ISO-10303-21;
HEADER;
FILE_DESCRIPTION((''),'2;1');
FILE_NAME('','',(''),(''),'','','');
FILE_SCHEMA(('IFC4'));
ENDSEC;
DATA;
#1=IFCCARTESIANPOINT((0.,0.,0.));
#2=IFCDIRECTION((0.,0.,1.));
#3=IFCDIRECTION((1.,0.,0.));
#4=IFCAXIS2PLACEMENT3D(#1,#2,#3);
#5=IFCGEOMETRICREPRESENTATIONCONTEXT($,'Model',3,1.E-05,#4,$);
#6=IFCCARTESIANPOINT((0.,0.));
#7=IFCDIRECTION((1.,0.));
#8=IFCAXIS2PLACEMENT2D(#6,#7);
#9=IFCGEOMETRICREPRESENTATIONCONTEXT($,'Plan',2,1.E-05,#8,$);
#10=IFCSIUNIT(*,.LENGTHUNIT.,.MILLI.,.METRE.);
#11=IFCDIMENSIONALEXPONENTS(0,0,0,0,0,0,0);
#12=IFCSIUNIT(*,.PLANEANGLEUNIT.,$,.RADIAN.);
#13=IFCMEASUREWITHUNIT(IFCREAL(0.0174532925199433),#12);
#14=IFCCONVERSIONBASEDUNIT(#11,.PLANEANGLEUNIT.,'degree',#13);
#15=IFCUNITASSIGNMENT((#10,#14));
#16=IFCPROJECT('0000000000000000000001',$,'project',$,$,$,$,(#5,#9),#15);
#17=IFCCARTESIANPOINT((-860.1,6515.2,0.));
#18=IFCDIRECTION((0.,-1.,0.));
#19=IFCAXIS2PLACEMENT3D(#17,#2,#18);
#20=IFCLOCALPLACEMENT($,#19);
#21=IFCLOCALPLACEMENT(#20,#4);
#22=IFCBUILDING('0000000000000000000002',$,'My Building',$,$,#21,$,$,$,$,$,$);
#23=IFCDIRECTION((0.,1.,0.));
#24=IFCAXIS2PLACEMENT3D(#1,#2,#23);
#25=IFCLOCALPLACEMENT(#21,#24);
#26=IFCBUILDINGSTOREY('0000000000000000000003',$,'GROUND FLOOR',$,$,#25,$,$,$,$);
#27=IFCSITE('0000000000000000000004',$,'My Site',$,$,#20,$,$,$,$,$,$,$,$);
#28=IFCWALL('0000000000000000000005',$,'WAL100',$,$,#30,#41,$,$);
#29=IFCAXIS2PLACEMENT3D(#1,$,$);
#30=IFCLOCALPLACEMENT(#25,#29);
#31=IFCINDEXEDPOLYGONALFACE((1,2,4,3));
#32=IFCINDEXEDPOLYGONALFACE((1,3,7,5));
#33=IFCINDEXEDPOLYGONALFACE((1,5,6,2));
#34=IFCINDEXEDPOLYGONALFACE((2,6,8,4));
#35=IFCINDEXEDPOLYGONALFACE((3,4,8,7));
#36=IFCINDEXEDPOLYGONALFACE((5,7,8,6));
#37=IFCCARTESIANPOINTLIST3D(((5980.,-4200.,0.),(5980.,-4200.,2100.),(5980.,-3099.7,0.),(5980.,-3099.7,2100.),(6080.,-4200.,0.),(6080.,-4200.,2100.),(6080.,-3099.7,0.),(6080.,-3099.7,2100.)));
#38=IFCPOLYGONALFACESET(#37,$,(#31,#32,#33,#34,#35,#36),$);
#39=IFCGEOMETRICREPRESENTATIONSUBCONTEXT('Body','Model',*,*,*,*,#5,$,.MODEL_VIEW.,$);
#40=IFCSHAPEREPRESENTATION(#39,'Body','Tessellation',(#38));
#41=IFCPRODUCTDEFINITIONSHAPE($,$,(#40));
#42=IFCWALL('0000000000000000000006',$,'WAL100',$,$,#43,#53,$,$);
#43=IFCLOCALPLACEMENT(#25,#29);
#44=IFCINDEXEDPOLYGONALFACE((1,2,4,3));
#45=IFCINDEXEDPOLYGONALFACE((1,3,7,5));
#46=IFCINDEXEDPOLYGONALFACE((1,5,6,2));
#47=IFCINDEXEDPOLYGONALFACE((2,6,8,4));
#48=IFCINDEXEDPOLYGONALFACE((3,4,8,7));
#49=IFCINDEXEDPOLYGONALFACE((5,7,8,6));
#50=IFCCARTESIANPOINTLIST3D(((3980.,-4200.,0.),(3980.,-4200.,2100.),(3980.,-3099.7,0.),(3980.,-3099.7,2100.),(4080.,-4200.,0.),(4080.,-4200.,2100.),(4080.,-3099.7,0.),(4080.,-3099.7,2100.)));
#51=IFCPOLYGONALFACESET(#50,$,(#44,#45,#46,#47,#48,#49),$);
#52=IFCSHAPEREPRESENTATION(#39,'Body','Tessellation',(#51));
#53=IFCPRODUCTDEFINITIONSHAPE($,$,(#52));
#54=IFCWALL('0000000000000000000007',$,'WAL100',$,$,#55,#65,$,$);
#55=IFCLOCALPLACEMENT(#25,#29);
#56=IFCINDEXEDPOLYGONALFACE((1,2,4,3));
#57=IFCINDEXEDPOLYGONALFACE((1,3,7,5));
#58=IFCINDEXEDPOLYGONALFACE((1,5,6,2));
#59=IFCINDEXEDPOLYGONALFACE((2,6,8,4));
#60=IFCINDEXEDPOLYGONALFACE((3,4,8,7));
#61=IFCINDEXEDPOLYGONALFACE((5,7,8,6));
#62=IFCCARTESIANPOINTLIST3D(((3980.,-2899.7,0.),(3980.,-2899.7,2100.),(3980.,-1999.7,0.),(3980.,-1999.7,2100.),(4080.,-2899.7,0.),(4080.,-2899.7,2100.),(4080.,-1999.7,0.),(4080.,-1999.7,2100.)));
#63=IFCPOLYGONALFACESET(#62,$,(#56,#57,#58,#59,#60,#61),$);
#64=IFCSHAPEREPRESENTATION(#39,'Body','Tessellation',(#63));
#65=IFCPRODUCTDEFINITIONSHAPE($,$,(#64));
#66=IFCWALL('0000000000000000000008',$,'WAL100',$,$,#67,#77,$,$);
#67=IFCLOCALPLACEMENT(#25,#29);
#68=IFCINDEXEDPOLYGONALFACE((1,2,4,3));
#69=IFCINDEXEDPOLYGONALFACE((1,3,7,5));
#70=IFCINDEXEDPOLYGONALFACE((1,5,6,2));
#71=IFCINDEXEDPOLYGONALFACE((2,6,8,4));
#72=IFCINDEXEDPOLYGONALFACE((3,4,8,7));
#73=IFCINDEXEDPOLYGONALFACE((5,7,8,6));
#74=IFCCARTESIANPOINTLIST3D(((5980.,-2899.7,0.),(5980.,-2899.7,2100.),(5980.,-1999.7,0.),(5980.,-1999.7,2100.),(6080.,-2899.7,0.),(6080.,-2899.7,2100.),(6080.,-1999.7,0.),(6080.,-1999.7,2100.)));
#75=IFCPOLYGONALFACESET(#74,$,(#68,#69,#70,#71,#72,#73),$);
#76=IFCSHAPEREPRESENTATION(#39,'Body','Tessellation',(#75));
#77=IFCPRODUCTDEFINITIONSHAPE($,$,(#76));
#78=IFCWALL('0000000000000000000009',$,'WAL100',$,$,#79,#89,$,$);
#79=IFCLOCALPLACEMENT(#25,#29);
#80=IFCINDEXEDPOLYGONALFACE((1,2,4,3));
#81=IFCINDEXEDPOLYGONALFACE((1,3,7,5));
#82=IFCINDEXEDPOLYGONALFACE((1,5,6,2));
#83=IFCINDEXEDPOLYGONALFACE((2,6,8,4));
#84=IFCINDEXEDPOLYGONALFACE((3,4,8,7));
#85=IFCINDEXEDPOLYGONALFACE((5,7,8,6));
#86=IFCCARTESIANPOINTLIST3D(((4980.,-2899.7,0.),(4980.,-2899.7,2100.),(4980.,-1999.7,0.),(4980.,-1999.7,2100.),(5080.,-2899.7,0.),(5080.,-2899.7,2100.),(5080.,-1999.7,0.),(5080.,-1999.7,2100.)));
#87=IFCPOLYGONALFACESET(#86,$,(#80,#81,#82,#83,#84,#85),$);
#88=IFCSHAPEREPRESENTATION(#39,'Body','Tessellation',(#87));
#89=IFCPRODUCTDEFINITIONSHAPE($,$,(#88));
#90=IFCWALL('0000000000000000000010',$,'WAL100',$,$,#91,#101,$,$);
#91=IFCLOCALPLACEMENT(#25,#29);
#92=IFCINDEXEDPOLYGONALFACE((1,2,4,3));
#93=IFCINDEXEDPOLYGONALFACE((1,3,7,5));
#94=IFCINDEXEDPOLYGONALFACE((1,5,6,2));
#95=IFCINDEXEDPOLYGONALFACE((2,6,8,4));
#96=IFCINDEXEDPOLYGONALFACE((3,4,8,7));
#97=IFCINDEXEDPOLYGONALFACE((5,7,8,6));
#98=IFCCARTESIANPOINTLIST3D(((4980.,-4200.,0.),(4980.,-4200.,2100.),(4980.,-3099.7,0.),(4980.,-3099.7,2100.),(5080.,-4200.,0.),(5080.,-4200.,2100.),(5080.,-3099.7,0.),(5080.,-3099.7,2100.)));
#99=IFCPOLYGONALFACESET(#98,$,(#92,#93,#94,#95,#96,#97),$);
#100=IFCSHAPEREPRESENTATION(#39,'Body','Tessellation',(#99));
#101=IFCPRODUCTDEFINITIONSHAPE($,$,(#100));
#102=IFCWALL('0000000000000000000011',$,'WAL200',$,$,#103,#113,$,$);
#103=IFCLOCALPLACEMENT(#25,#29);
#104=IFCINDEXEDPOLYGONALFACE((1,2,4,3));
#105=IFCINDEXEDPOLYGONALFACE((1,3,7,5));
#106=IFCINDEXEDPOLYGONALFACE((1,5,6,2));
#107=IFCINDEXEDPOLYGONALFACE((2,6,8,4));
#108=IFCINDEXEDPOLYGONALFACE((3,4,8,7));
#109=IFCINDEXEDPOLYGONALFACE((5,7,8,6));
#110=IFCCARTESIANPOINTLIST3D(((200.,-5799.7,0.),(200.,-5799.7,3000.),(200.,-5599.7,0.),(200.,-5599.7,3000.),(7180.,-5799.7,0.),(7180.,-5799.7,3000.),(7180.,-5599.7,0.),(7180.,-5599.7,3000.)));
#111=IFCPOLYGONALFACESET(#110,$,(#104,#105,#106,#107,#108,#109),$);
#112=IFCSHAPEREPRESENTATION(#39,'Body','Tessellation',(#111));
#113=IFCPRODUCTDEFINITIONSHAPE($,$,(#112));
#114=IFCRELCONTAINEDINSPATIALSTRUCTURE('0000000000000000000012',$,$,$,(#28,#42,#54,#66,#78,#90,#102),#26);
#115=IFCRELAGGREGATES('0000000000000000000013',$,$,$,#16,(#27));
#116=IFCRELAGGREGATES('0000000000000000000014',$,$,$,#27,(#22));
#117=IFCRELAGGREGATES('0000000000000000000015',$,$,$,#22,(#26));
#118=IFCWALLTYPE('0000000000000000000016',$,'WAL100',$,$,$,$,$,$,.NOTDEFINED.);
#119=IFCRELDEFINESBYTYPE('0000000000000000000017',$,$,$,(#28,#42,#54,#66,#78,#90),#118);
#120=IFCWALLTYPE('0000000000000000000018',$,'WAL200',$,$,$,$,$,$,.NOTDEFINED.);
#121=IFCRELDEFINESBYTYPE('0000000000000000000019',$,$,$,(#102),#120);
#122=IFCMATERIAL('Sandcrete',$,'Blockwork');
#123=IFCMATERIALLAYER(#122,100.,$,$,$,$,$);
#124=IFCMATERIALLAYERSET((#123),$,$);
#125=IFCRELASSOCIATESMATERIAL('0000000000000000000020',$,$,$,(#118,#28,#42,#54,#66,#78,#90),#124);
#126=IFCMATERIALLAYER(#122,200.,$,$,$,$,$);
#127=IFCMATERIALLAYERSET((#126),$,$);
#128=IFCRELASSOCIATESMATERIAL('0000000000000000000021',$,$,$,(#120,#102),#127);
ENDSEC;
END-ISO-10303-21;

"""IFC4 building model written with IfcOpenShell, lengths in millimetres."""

from ifc_helpers import new_model, entity, si_unit, converted_unit, frame, origin_with_axes, origin_2d_with_axis, place, context, subcontext, project, spatial, indexed_curve, outline, extrude, material, layer, layer_set, layer_usage, type_object, element, save


model = new_model("IFC4")

# Units and contexts
model_context = context("Model", 3, precision=1e-05, world=origin_with_axes())
plan_context = context("Plan", 2, precision=1e-05, world=origin_2d_with_axis())
body_context_1 = subcontext(model_context, "Body", "Model", "MODEL_VIEW")
ifc_project = project(units=[si_unit("LENGTHUNIT", "METRE", prefix="MILLI"), converted_unit("PLANEANGLEUNIT", "degree", entity("IfcReal", 0.0174532925199433), si_unit("PLANEANGLEUNIT", "RADIAN"), dimensions=[0, 0, 0, 0, 0, 0, 0])], contexts=[model_context, plan_context])

# Site, building, storey
site_placement = place(None, frame((-860.1, 6515.2, 0.0), z_axis=(0.0, 0.0, 1.0), x_axis=(0.0, -1.0, 0.0)))
site = spatial("IfcSite", under=ifc_project, at=site_placement, Name="My Site")
building_placement = place(site_placement, frame((0.0, 0.0, 0.0), z_axis=(0.0, 0.0, 1.0), x_axis=(1.0, 0.0, 0.0)))
building = spatial("IfcBuilding", under=site, at=building_placement, Name="My Building")
storey_placement = place(building_placement, frame((0.0, 0.0, 0.0), z_axis=(0.0, 0.0, 1.0), x_axis=(0.0, 1.0, 0.0)))
storey = spatial("IfcBuildingStorey", under=building, at=storey_placement, Name="GROUND FLOOR")

# Walls
ifc_material = material(Name="Sandcrete", Category="Blockwork")
ifc_layer_1 = layer(ifc_material, 100.0)
ifc_layer_set_1 = layer_set([ifc_layer_1])
ifc_layer_usage_1 = layer_usage(ifc_layer_set_1, "AXIS2", "POSITIVE", 0.0)
wall_type_1 = type_object("IfcWallType", Name="WAL100", PredefinedType="NOTDEFINED", material=ifc_layer_set_1)
wall_1_placement = place(storey_placement, frame((5980.0, -3099.7, 0.0), z_axis=(0.0, 0.0, 1.0), x_axis=(0.0, -1.0, 0.0)))
element("IfcWall", 1, at=wall_1_placement, inside=storey, type_object=wall_type_1, material=ifc_layer_usage_1, Name="WAL100", context=body_context_1, shape_type="SweptSolid", body=[
    extrude(outline(indexed_curve([(0.0, 0.0), (0.0, 100.0), (1100.3, 100.0), (1100.3, 0.0), (0.0, 0.0)], self_intersect=False)), origin_with_axes(), (0.0, 0.0, 1.0), 2100.0),
])
ifc_layer_usage_2 = layer_usage(ifc_layer_set_1, "AXIS2", "POSITIVE", 0.0)
wall_2_placement = place(storey_placement, frame((3980.0, -3099.7, 0.0), z_axis=(0.0, 0.0, 1.0), x_axis=(-0.000001, -1.0, 0.0)))
element("IfcWall", 2, at=wall_2_placement, inside=storey, type_object=wall_type_1, material=ifc_layer_usage_2, Name="WAL100", context=body_context_1, shape_type="SweptSolid", body=[
    extrude(outline(indexed_curve([(0.0, 0.0), (0.0, 100.0), (1100.3, 100.0), (1100.3, 0.0), (0.0, 0.0)], self_intersect=False)), origin_with_axes(), (0.0, 0.0, 1.0), 2100.0),
])
ifc_layer_usage_3 = layer_usage(ifc_layer_set_1, "AXIS2", "POSITIVE", 0.0)
wall_3_placement = place(storey_placement, frame((3980.0, -1999.7, 0.0), z_axis=(0.0, 0.0, 1.0), x_axis=(-0.000001, -1.0, 0.0)))
element("IfcWall", 3, at=wall_3_placement, inside=storey, type_object=wall_type_1, material=ifc_layer_usage_3, Name="WAL100", context=body_context_1, shape_type="SweptSolid", body=[
    extrude(outline(indexed_curve([(0.0, 0.0), (0.0, 100.0), (900.0, 100.0), (900.0, 0.0), (0.0, 0.0)], self_intersect=False)), origin_with_axes(), (0.0, 0.0, 1.0), 2100.0),
])
ifc_layer_usage_4 = layer_usage(ifc_layer_set_1, "AXIS2", "POSITIVE", 0.0)
wall_4_placement = place(storey_placement, frame((5980.0, -1999.7, 0.0), z_axis=(0.0, 0.0, 1.0), x_axis=(0.0, -1.0, 0.0)))
element("IfcWall", 4, at=wall_4_placement, inside=storey, type_object=wall_type_1, material=ifc_layer_usage_4, Name="WAL100", context=body_context_1, shape_type="SweptSolid", body=[
    extrude(outline(indexed_curve([(0.0, 0.0), (0.0, 100.0), (900.0, 100.0), (900.0, 0.0), (0.0, 0.0)], self_intersect=False)), origin_with_axes(), (0.0, 0.0, 1.0), 2100.0),
])
ifc_layer_usage_5 = layer_usage(ifc_layer_set_1, "AXIS2", "POSITIVE", 0.0)
wall_5_placement = place(storey_placement, frame((4980.0, -1999.7, 0.0), z_axis=(0.0, 0.0, 1.0), x_axis=(-0.000001, -1.0, 0.0)))
element("IfcWall", 5, at=wall_5_placement, inside=storey, type_object=wall_type_1, material=ifc_layer_usage_5, Name="WAL100", context=body_context_1, shape_type="SweptSolid", body=[
    extrude(outline(indexed_curve([(0.0, 0.0), (0.0, 100.0), (900.0, 100.0), (900.0, 0.0), (0.0, 0.0)], self_intersect=False)), origin_with_axes(), (0.0, 0.0, 1.0), 2100.0),
])
ifc_layer_usage_6 = layer_usage(ifc_layer_set_1, "AXIS2", "POSITIVE", 0.0)
wall_6_placement = place(storey_placement, frame((4980.0, -3099.7, 0.0), z_axis=(0.0, 0.0, 1.0), x_axis=(-0.000001, -1.0, 0.0)))
element("IfcWall", 6, at=wall_6_placement, inside=storey, type_object=wall_type_1, material=ifc_layer_usage_6, Name="WAL100", context=body_context_1, shape_type="SweptSolid", body=[
    extrude(outline(indexed_curve([(0.0, 0.0), (0.0, 100.0), (1100.3, 100.0), (1100.3, 0.0), (0.0, 0.0)], self_intersect=False)), origin_with_axes(), (0.0, 0.0, 1.0), 2100.0),
])

# Wall
ifc_layer_2 = layer(ifc_material, 200.0)
ifc_layer_set_2 = layer_set([ifc_layer_2])
ifc_layer_usage_7 = layer_usage(ifc_layer_set_2, "AXIS2", "POSITIVE", 0.0)
wall_type_2 = type_object("IfcWallType", Name="WAL200", PredefinedType="NOTDEFINED", material=ifc_layer_set_2)
wall_7_placement = place(storey_placement, frame((7180.0, -5599.7, 0.0), z_axis=(0.0, 0.0, 1.0), x_axis=(-1.0, 0.000001, 0.0)))
element("IfcWall", 7, at=wall_7_placement, inside=storey, type_object=wall_type_2, material=ifc_layer_usage_7, Name="WAL200", context=body_context_1, shape_type="SweptSolid", body=[
    extrude(outline(indexed_curve([(0.0, 0.0), (0.0, 200.0), (6980.0, 200.0), (6980.0, 0.0), (0.0, 0.0)], self_intersect=False)), origin_with_axes(), (0.0, 0.0, 1.0), 3000.0),
])

save(model, "model.ifc")
